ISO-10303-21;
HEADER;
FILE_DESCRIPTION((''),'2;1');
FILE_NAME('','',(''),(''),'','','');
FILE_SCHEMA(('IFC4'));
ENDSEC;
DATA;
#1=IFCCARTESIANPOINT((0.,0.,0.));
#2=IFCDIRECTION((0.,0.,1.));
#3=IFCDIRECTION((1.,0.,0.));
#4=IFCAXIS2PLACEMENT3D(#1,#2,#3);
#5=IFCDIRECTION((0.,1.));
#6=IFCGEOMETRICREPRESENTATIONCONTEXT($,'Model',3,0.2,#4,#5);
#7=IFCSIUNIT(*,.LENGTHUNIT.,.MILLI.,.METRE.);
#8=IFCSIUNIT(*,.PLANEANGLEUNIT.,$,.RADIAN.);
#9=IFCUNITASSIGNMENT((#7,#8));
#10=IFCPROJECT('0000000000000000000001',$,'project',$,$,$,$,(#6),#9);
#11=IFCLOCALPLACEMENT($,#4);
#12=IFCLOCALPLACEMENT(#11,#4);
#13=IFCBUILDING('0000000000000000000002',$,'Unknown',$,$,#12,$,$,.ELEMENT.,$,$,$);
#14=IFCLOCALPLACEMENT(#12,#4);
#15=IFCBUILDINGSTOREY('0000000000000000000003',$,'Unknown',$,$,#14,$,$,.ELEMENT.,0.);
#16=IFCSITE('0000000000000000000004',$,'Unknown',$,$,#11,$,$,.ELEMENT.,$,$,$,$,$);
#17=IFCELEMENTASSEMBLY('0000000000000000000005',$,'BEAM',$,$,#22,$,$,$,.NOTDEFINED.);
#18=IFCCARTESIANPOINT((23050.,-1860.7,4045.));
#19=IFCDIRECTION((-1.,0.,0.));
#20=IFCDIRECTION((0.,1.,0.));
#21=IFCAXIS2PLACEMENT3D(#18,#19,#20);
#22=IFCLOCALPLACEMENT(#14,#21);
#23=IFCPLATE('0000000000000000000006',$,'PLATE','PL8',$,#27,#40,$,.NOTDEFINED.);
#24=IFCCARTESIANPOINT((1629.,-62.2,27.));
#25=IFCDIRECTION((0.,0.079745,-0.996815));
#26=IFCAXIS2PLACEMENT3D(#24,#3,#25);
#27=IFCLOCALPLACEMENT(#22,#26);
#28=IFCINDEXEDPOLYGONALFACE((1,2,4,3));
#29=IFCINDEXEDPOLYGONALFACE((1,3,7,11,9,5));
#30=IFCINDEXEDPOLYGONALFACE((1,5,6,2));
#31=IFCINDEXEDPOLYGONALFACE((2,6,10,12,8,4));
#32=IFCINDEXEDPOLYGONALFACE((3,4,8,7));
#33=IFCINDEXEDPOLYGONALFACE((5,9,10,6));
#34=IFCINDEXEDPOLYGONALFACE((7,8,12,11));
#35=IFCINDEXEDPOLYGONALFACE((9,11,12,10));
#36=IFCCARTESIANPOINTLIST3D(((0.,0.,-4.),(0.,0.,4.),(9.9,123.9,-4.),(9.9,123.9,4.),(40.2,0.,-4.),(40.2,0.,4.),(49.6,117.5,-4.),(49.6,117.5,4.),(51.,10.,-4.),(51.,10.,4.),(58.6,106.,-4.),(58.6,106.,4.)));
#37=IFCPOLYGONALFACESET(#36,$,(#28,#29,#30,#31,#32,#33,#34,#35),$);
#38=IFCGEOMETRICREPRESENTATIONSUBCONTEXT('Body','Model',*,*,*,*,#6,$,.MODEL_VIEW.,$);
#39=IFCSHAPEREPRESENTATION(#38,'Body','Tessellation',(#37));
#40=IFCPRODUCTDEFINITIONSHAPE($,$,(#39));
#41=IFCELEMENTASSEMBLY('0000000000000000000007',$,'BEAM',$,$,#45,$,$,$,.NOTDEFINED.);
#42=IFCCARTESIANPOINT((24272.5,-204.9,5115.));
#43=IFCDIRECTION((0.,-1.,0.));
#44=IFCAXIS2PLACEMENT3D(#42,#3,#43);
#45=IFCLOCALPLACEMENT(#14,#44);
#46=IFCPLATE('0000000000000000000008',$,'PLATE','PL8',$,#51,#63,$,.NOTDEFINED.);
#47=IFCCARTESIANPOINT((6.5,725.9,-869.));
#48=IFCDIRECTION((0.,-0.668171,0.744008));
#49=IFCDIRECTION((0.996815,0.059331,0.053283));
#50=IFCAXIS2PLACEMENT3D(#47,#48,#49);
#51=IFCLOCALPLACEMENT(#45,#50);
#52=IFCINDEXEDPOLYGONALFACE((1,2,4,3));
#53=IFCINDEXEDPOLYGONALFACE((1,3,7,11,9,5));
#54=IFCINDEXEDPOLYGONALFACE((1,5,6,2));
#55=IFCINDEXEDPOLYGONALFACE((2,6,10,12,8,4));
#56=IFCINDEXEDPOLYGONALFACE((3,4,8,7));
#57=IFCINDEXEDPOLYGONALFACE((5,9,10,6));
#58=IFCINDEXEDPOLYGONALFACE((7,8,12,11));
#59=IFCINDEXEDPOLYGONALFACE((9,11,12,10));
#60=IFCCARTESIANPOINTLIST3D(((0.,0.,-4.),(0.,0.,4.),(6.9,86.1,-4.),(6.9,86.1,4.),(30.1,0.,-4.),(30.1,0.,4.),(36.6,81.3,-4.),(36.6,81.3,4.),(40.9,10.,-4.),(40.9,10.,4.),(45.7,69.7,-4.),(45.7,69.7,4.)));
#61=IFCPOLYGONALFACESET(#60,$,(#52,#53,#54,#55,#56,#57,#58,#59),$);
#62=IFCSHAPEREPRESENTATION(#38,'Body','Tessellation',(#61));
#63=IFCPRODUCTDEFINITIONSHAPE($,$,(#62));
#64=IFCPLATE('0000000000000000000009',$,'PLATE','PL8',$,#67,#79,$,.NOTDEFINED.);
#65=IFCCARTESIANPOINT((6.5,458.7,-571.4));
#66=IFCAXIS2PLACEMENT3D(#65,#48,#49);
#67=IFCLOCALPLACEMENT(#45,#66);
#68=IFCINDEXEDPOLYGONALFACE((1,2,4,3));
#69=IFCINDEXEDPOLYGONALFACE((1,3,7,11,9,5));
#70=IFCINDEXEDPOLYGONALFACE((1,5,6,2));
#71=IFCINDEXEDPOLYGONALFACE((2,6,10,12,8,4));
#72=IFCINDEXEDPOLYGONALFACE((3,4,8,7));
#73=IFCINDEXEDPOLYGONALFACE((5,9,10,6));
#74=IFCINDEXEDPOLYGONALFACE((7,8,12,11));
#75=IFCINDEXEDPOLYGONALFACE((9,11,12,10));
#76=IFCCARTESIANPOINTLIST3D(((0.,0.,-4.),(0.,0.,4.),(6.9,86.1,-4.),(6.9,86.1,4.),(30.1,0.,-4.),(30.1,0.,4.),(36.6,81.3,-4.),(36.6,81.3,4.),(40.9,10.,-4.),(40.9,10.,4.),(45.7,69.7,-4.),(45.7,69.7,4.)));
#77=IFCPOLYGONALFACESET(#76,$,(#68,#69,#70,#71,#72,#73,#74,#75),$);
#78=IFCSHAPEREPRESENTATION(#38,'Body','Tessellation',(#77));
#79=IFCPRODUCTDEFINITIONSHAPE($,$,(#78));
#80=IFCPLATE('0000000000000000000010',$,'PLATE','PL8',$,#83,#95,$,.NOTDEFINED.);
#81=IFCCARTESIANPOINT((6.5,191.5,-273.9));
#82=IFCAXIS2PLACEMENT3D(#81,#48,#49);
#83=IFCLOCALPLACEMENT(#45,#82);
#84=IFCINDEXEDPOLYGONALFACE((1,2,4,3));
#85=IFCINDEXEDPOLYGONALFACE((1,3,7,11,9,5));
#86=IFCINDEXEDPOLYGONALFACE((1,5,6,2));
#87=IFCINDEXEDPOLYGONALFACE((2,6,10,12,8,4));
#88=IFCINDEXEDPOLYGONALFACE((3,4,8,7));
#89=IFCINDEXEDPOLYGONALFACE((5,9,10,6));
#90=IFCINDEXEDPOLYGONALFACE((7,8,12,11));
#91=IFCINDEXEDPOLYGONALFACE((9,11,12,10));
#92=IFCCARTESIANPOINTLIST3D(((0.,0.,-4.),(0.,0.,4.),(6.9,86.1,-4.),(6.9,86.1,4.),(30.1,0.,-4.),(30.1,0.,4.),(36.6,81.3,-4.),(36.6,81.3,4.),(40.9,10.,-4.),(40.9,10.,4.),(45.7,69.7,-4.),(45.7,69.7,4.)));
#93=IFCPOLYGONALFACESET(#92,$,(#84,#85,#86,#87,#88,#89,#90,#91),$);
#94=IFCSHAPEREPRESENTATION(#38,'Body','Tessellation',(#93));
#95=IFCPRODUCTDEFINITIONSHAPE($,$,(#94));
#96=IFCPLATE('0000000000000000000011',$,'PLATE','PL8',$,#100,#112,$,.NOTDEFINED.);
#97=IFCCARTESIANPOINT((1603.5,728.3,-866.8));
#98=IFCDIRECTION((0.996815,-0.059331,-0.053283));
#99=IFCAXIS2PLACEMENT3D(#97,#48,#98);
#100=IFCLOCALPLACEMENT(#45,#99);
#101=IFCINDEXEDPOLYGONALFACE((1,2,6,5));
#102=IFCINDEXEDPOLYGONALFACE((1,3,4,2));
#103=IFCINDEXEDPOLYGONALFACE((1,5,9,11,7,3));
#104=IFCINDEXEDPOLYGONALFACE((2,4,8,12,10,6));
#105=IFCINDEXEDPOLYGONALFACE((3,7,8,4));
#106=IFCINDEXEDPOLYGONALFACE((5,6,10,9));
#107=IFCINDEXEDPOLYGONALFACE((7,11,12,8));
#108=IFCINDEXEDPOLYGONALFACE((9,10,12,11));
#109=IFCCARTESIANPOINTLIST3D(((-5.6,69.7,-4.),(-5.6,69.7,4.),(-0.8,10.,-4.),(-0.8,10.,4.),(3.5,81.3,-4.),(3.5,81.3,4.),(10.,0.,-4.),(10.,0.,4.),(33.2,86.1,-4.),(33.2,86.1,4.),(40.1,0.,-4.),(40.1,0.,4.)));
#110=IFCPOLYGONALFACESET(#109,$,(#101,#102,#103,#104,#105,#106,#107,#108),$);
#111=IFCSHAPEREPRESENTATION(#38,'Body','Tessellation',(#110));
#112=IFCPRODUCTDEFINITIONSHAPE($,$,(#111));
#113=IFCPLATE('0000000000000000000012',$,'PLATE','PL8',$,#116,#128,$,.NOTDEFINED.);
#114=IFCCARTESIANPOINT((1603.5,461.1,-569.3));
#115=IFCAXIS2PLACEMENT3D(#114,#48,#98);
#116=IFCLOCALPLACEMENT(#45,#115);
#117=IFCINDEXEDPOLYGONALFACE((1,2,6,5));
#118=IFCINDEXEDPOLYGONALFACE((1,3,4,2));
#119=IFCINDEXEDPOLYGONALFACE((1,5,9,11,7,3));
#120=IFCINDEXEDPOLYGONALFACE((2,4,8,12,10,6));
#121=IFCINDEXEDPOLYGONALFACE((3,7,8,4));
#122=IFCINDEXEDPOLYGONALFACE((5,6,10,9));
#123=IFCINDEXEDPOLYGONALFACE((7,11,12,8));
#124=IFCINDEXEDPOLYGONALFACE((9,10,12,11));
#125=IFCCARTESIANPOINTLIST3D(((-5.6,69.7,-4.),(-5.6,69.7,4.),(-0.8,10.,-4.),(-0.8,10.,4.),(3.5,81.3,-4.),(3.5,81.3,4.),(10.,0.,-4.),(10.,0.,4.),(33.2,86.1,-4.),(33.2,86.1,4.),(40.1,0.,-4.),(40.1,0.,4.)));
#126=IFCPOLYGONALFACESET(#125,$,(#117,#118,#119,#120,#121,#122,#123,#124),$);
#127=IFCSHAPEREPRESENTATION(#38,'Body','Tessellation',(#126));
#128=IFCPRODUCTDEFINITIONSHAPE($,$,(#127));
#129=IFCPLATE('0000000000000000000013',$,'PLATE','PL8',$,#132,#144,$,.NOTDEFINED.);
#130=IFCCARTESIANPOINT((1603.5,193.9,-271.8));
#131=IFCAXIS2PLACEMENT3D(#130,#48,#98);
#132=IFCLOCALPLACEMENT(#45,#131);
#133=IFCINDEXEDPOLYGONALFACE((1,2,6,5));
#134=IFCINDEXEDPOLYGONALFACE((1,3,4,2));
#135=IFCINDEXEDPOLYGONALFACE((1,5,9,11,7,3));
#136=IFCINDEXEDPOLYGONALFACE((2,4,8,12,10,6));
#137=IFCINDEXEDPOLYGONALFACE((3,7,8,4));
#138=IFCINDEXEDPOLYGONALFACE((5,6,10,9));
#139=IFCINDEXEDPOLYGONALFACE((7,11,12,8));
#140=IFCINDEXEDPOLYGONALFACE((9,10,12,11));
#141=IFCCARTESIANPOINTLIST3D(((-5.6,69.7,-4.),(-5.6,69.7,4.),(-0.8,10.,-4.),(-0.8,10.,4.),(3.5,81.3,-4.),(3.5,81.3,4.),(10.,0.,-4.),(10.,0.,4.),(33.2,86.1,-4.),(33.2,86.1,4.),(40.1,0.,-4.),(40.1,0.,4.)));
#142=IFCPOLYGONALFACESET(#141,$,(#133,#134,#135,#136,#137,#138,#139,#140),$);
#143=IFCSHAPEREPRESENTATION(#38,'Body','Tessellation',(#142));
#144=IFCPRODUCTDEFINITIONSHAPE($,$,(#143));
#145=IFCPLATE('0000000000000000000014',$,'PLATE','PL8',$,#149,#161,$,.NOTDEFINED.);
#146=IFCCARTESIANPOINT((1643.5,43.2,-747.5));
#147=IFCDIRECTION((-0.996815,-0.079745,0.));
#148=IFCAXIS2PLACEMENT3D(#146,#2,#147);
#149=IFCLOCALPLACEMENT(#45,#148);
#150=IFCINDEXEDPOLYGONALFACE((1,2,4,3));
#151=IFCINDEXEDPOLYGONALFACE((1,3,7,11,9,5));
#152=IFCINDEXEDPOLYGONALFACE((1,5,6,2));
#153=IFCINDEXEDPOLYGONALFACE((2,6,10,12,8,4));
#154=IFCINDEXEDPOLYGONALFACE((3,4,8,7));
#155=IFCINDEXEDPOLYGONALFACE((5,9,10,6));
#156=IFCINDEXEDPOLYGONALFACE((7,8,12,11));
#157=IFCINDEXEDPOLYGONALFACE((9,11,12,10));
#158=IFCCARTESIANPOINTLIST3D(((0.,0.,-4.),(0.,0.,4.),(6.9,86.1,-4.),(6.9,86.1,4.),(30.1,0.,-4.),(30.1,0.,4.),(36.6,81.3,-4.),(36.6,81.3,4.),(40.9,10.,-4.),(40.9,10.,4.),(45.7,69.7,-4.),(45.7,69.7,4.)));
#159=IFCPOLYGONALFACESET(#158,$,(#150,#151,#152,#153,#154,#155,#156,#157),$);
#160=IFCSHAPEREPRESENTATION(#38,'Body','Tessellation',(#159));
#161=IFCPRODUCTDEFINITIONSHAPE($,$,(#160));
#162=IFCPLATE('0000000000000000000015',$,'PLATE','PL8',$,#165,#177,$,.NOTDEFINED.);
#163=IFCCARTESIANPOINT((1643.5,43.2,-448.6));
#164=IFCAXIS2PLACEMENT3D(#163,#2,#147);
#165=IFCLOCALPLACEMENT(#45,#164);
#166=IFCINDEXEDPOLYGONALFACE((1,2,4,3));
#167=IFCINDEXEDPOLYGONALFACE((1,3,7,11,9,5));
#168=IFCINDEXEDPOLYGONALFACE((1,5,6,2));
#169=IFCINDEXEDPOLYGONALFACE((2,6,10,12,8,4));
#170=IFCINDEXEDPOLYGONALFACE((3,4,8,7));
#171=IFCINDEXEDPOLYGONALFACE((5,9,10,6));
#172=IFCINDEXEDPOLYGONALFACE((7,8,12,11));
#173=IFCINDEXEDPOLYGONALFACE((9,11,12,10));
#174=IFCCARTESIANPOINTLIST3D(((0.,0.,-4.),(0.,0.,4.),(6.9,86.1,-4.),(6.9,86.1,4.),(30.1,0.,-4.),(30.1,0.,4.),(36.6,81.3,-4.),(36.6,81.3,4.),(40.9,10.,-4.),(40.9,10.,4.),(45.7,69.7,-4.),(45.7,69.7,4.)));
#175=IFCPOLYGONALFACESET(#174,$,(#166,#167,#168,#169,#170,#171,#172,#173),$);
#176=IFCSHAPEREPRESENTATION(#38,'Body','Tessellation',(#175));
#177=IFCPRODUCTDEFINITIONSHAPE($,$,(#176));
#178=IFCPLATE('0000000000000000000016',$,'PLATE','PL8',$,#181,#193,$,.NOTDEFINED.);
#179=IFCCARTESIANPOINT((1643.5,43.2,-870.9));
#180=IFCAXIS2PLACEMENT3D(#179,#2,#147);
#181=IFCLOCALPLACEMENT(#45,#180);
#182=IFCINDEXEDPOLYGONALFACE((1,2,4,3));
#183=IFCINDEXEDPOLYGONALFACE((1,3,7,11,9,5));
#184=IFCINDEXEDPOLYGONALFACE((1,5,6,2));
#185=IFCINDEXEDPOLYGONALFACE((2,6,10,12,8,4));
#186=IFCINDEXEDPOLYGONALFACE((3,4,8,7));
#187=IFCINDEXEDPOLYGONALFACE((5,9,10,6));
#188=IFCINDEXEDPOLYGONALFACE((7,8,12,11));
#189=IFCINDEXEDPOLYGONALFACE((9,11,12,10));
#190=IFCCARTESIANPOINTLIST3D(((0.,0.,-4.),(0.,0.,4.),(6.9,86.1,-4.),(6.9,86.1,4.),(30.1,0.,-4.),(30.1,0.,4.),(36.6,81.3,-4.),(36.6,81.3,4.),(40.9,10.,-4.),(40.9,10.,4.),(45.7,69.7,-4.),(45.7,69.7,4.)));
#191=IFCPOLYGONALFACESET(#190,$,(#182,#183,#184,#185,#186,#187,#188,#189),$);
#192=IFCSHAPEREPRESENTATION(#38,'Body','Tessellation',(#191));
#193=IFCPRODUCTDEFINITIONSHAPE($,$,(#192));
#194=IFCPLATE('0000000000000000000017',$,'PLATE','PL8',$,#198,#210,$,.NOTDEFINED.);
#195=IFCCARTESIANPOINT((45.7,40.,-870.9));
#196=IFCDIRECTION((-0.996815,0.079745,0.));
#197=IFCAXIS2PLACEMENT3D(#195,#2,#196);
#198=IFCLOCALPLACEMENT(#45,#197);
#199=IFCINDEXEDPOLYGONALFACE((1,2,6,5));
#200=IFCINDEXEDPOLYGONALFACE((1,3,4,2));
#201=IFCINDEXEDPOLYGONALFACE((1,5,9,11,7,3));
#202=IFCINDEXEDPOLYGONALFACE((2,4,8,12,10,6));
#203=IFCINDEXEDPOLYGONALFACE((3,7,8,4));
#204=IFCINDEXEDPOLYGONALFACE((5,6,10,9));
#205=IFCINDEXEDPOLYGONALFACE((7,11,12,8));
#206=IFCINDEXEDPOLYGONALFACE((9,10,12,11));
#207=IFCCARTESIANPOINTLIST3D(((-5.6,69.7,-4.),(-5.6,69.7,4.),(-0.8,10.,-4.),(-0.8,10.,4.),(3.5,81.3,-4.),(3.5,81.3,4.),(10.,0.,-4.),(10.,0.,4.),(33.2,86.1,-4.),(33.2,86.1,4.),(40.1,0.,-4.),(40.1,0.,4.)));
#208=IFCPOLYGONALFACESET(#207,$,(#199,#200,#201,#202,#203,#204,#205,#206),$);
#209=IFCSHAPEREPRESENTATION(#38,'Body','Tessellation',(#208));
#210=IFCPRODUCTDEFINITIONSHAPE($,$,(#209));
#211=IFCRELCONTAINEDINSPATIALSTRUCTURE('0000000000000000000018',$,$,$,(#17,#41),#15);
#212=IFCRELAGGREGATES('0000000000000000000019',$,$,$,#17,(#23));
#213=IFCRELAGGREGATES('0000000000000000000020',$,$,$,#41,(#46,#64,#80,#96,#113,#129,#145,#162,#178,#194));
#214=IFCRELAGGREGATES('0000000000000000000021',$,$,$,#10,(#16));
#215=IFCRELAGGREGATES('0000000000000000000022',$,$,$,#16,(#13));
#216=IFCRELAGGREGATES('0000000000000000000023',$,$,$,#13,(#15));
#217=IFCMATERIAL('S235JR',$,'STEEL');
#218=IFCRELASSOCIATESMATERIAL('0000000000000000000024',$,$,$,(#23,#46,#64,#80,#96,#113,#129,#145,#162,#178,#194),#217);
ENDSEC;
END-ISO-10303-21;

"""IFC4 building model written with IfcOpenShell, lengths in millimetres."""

from ifc_helpers import new_model, si_unit, direction, frame, origin_with_axes, place, context, subcontext, project, spatial, line, indexed_curve, outline, extrude, material, element, aggregate, save


model = new_model("IFC4")

# Units and contexts
model_context = context("Model", 3, precision=0.2, world=origin_with_axes(), true_north=direction((0.0, 1.0)))
body_context = subcontext(model_context, "Body", "Model", "MODEL_VIEW")
ifc_project = project(units=[si_unit("LENGTHUNIT", "METRE", prefix="MILLI"), si_unit("PLANEANGLEUNIT", "RADIAN")], contexts=[model_context])

# Site, building, storey
site_placement = place(None, origin_with_axes())
site = spatial("IfcSite", under=ifc_project, at=site_placement, Name="Unknown", CompositionType="ELEMENT")
building_placement = place(site_placement, origin_with_axes())
building = spatial("IfcBuilding", under=site, at=building_placement, Name="Unknown", CompositionType="ELEMENT")
storey_placement = place(building_placement, origin_with_axes())
storey = spatial("IfcBuildingStorey", under=building, at=storey_placement, Name="Unknown", CompositionType="ELEMENT", Elevation=0.0)

# Shared definitions
ifc_material_1 = material(Name="S235JR", Category="STEEL")

# Element assembly, plate
assembly_1_placement = place(storey_placement, frame((23050.0, -1860.7, 4045.0), z_axis=(-1.0, 0.0, 0.0), x_axis=(0.0, 1.0, 0.0)))
assembly_1 = element("IfcElementAssembly", 1, at=assembly_1_placement, inside=storey, Name="BEAM", PredefinedType="NOTDEFINED")
plate_1_placement = place(assembly_1_placement, frame((1629.0, -62.2, 27.0), z_axis=(1.0, 0.0, 0.0), x_axis=(0.0, 0.079745, -0.996815)))
plate_1 = element("IfcPlate", 2, at=plate_1_placement, material=ifc_material_1, Name="PLATE", Description="PL8", PredefinedType="NOTDEFINED", context=body_context, shape_type="SolidModel", body=[
    extrude(outline(indexed_curve([(0.0, 0.0), (40.2, 0.0), (51.0, 10.0), (58.6, 106.0), (49.6, 117.5), (9.9, 123.9)], segments=[line(1, 2, 3, 4, 5, 6, 1)])), frame((0.0, 0.0, 4.0), z_axis=(0.0, 0.0, 1.0), x_axis=(1.0, 0.0, 0.0)), (0.0, 0.0, -1.0), 8.0),
])
aggregate(assembly_1, [plate_1])

# Element assembly, plates
assembly_2_placement = place(storey_placement, frame((24272.5, -204.9, 5115.0), z_axis=(1.0, 0.0, 0.0), x_axis=(0.0, -1.0, 0.0)))
assembly_2 = element("IfcElementAssembly", 3, at=assembly_2_placement, inside=storey, Name="BEAM", PredefinedType="NOTDEFINED")
plate_2_placement = place(assembly_2_placement, frame((6.5, 725.9, -869.0), z_axis=(0.0, -0.668171, 0.744008), x_axis=(0.996815, 0.059331, 0.053283)))
plate_2 = element("IfcPlate", 4, at=plate_2_placement, material=ifc_material_1, Name="PLATE", Description="PL8", PredefinedType="NOTDEFINED", context=body_context, shape_type="SolidModel", body=[
    extrude(outline(indexed_curve([(0.0, 0.0), (30.1, 0.0), (40.9, 10.0), (45.7, 69.7), (36.6, 81.3), (6.9, 86.1)], segments=[line(1, 2, 3, 4, 5, 6, 1)])), frame((0.0, 0.0, 4.0), z_axis=(0.0, 0.0, 1.0), x_axis=(1.0, 0.0, 0.0)), (0.0, 0.0, -1.0), 8.0),
])
plate_3_placement = place(assembly_2_placement, frame((6.5, 458.7, -571.4), z_axis=(0.0, -0.668171, 0.744008), x_axis=(0.996815, 0.059331, 0.053283)))
plate_3 = element("IfcPlate", 5, at=plate_3_placement, material=ifc_material_1, Name="PLATE", Description="PL8", PredefinedType="NOTDEFINED", context=body_context, shape_type="SolidModel", body=[
    extrude(outline(indexed_curve([(0.0, 0.0), (30.1, 0.0), (40.9, 10.0), (45.7, 69.7), (36.6, 81.3), (6.9, 86.1)], segments=[line(1, 2, 3, 4, 5, 6, 1)])), frame((0.0, 0.0, 4.0), z_axis=(0.0, 0.0, 1.0), x_axis=(1.0, 0.0, 0.0)), (0.0, 0.0, -1.0), 8.0),
])
plate_4_placement = place(assembly_2_placement, frame((6.5, 191.5, -273.9), z_axis=(0.0, -0.668171, 0.744008), x_axis=(0.996815, 0.059331, 0.053283)))
plate_4 = element("IfcPlate", 6, at=plate_4_placement, material=ifc_material_1, Name="PLATE", Description="PL8", PredefinedType="NOTDEFINED", context=body_context, shape_type="SolidModel", body=[
    extrude(outline(indexed_curve([(0.0, 0.0), (30.1, 0.0), (40.9, 10.0), (45.7, 69.7), (36.6, 81.3), (6.9, 86.1)], segments=[line(1, 2, 3, 4, 5, 6, 1)])), frame((0.0, 0.0, 4.0), z_axis=(0.0, 0.0, 1.0), x_axis=(1.0, 0.0, 0.0)), (0.0, 0.0, -1.0), 8.0),
])
plate_5_placement = place(assembly_2_placement, frame((1603.5, 728.3, -866.8), z_axis=(0.0, -0.668171, 0.744008), x_axis=(0.996815, -0.059331, -0.053283)))
plate_5 = element("IfcPlate", 7, at=plate_5_placement, material=ifc_material_1, Name="PLATE", Description="PL8", PredefinedType="NOTDEFINED", context=body_context, shape_type="SolidModel", body=[
    extrude(outline(indexed_curve([(-0.8, 10.0), (10.0, 0.0), (40.1, 0.0), (33.2, 86.1), (3.5, 81.3), (-5.6, 69.7)], segments=[line(1, 2, 3, 4, 5, 6, 1)])), frame((0.0, 0.0, 4.0), z_axis=(0.0, 0.0, 1.0), x_axis=(1.0, 0.0, 0.0)), (0.0, 0.0, -1.0), 8.0),
])
plate_6_placement = place(assembly_2_placement, frame((1603.5, 461.1, -569.3), z_axis=(0.0, -0.668171, 0.744008), x_axis=(0.996815, -0.059331, -0.053283)))
plate_6 = element("IfcPlate", 8, at=plate_6_placement, material=ifc_material_1, Name="PLATE", Description="PL8", PredefinedType="NOTDEFINED", context=body_context, shape_type="SolidModel", body=[
    extrude(outline(indexed_curve([(-0.8, 10.0), (10.0, 0.0), (40.1, 0.0), (33.2, 86.1), (3.5, 81.3), (-5.6, 69.7)], segments=[line(1, 2, 3, 4, 5, 6, 1)])), frame((0.0, 0.0, 4.0), z_axis=(0.0, 0.0, 1.0), x_axis=(1.0, 0.0, 0.0)), (0.0, 0.0, -1.0), 8.0),
])
plate_7_placement = place(assembly_2_placement, frame((1603.5, 193.9, -271.8), z_axis=(0.0, -0.668171, 0.744008), x_axis=(0.996815, -0.059331, -0.053283)))
plate_7 = element("IfcPlate", 9, at=plate_7_placement, material=ifc_material_1, Name="PLATE", Description="PL8", PredefinedType="NOTDEFINED", context=body_context, shape_type="SolidModel", body=[
    extrude(outline(indexed_curve([(-0.8, 10.0), (10.0, 0.0), (40.1, 0.0), (33.2, 86.1), (3.5, 81.3), (-5.6, 69.7)], segments=[line(1, 2, 3, 4, 5, 6, 1)])), frame((0.0, 0.0, 4.0), z_axis=(0.0, 0.0, 1.0), x_axis=(1.0, 0.0, 0.0)), (0.0, 0.0, -1.0), 8.0),
])
plate_8_placement = place(assembly_2_placement, frame((1643.5, 43.2, -747.5), z_axis=(0.0, 0.0, 1.0), x_axis=(-0.996815, -0.079745, 0.0)))
plate_8 = element("IfcPlate", 10, at=plate_8_placement, material=ifc_material_1, Name="PLATE", Description="PL8", PredefinedType="NOTDEFINED", context=body_context, shape_type="SolidModel", body=[
    extrude(outline(indexed_curve([(0.0, 0.0), (30.1, 0.0), (40.9, 10.0), (45.7, 69.7), (36.6, 81.3), (6.9, 86.1)], segments=[line(1, 2, 3, 4, 5, 6, 1)])), frame((0.0, 0.0, 4.0), z_axis=(0.0, 0.0, 1.0), x_axis=(1.0, 0.0, 0.0)), (0.0, 0.0, -1.0), 8.0),
])
plate_9_placement = place(assembly_2_placement, frame((1643.5, 43.2, -448.6), z_axis=(0.0, 0.0, 1.0), x_axis=(-0.996815, -0.079745, 0.0)))
plate_9 = element("IfcPlate", 11, at=plate_9_placement, material=ifc_material_1, Name="PLATE", Description="PL8", PredefinedType="NOTDEFINED", context=body_context, shape_type="SolidModel", body=[
    extrude(outline(indexed_curve([(0.0, 0.0), (30.1, 0.0), (40.9, 10.0), (45.7, 69.7), (36.6, 81.3), (6.9, 86.1)], segments=[line(1, 2, 3, 4, 5, 6, 1)])), frame((0.0, 0.0, 4.0), z_axis=(0.0, 0.0, 1.0), x_axis=(1.0, 0.0, 0.0)), (0.0, 0.0, -1.0), 8.0),
])
plate_10_placement = place(assembly_2_placement, frame((1643.5, 43.2, -870.9), z_axis=(0.0, 0.0, 1.0), x_axis=(-0.996815, -0.079745, 0.0)))
plate_10 = element("IfcPlate", 12, at=plate_10_placement, material=ifc_material_1, Name="PLATE", Description="PL8", PredefinedType="NOTDEFINED", context=body_context, shape_type="SolidModel", body=[
    extrude(outline(indexed_curve([(0.0, 0.0), (30.1, 0.0), (40.9, 10.0), (45.7, 69.7), (36.6, 81.3), (6.9, 86.1)], segments=[line(1, 2, 3, 4, 5, 6, 1)])), frame((0.0, 0.0, 4.0), z_axis=(0.0, 0.0, 1.0), x_axis=(1.0, 0.0, 0.0)), (0.0, 0.0, -1.0), 8.0),
])
plate_11_placement = place(assembly_2_placement, frame((45.7, 40.0, -870.9), z_axis=(0.0, 0.0, 1.0), x_axis=(-0.996815, 0.079745, 0.0)))
plate_11 = element("IfcPlate", 13, at=plate_11_placement, material=ifc_material_1, Name="PLATE", Description="PL8", PredefinedType="NOTDEFINED", context=body_context, shape_type="SolidModel", body=[
    extrude(outline(indexed_curve([(-0.8, 10.0), (10.0, 0.0), (40.1, 0.0), (33.2, 86.1), (3.5, 81.3), (-5.6, 69.7)], segments=[line(1, 2, 3, 4, 5, 6, 1)])), frame((0.0, 0.0, 4.0), z_axis=(0.0, 0.0, 1.0), x_axis=(1.0, 0.0, 0.0)), (0.0, 0.0, -1.0), 8.0),
])
aggregate(assembly_2, [plate_2, plate_3, plate_4, plate_5, plate_6, plate_7, plate_8, plate_9, plate_10, plate_11])

save(model, "model.ifc")
